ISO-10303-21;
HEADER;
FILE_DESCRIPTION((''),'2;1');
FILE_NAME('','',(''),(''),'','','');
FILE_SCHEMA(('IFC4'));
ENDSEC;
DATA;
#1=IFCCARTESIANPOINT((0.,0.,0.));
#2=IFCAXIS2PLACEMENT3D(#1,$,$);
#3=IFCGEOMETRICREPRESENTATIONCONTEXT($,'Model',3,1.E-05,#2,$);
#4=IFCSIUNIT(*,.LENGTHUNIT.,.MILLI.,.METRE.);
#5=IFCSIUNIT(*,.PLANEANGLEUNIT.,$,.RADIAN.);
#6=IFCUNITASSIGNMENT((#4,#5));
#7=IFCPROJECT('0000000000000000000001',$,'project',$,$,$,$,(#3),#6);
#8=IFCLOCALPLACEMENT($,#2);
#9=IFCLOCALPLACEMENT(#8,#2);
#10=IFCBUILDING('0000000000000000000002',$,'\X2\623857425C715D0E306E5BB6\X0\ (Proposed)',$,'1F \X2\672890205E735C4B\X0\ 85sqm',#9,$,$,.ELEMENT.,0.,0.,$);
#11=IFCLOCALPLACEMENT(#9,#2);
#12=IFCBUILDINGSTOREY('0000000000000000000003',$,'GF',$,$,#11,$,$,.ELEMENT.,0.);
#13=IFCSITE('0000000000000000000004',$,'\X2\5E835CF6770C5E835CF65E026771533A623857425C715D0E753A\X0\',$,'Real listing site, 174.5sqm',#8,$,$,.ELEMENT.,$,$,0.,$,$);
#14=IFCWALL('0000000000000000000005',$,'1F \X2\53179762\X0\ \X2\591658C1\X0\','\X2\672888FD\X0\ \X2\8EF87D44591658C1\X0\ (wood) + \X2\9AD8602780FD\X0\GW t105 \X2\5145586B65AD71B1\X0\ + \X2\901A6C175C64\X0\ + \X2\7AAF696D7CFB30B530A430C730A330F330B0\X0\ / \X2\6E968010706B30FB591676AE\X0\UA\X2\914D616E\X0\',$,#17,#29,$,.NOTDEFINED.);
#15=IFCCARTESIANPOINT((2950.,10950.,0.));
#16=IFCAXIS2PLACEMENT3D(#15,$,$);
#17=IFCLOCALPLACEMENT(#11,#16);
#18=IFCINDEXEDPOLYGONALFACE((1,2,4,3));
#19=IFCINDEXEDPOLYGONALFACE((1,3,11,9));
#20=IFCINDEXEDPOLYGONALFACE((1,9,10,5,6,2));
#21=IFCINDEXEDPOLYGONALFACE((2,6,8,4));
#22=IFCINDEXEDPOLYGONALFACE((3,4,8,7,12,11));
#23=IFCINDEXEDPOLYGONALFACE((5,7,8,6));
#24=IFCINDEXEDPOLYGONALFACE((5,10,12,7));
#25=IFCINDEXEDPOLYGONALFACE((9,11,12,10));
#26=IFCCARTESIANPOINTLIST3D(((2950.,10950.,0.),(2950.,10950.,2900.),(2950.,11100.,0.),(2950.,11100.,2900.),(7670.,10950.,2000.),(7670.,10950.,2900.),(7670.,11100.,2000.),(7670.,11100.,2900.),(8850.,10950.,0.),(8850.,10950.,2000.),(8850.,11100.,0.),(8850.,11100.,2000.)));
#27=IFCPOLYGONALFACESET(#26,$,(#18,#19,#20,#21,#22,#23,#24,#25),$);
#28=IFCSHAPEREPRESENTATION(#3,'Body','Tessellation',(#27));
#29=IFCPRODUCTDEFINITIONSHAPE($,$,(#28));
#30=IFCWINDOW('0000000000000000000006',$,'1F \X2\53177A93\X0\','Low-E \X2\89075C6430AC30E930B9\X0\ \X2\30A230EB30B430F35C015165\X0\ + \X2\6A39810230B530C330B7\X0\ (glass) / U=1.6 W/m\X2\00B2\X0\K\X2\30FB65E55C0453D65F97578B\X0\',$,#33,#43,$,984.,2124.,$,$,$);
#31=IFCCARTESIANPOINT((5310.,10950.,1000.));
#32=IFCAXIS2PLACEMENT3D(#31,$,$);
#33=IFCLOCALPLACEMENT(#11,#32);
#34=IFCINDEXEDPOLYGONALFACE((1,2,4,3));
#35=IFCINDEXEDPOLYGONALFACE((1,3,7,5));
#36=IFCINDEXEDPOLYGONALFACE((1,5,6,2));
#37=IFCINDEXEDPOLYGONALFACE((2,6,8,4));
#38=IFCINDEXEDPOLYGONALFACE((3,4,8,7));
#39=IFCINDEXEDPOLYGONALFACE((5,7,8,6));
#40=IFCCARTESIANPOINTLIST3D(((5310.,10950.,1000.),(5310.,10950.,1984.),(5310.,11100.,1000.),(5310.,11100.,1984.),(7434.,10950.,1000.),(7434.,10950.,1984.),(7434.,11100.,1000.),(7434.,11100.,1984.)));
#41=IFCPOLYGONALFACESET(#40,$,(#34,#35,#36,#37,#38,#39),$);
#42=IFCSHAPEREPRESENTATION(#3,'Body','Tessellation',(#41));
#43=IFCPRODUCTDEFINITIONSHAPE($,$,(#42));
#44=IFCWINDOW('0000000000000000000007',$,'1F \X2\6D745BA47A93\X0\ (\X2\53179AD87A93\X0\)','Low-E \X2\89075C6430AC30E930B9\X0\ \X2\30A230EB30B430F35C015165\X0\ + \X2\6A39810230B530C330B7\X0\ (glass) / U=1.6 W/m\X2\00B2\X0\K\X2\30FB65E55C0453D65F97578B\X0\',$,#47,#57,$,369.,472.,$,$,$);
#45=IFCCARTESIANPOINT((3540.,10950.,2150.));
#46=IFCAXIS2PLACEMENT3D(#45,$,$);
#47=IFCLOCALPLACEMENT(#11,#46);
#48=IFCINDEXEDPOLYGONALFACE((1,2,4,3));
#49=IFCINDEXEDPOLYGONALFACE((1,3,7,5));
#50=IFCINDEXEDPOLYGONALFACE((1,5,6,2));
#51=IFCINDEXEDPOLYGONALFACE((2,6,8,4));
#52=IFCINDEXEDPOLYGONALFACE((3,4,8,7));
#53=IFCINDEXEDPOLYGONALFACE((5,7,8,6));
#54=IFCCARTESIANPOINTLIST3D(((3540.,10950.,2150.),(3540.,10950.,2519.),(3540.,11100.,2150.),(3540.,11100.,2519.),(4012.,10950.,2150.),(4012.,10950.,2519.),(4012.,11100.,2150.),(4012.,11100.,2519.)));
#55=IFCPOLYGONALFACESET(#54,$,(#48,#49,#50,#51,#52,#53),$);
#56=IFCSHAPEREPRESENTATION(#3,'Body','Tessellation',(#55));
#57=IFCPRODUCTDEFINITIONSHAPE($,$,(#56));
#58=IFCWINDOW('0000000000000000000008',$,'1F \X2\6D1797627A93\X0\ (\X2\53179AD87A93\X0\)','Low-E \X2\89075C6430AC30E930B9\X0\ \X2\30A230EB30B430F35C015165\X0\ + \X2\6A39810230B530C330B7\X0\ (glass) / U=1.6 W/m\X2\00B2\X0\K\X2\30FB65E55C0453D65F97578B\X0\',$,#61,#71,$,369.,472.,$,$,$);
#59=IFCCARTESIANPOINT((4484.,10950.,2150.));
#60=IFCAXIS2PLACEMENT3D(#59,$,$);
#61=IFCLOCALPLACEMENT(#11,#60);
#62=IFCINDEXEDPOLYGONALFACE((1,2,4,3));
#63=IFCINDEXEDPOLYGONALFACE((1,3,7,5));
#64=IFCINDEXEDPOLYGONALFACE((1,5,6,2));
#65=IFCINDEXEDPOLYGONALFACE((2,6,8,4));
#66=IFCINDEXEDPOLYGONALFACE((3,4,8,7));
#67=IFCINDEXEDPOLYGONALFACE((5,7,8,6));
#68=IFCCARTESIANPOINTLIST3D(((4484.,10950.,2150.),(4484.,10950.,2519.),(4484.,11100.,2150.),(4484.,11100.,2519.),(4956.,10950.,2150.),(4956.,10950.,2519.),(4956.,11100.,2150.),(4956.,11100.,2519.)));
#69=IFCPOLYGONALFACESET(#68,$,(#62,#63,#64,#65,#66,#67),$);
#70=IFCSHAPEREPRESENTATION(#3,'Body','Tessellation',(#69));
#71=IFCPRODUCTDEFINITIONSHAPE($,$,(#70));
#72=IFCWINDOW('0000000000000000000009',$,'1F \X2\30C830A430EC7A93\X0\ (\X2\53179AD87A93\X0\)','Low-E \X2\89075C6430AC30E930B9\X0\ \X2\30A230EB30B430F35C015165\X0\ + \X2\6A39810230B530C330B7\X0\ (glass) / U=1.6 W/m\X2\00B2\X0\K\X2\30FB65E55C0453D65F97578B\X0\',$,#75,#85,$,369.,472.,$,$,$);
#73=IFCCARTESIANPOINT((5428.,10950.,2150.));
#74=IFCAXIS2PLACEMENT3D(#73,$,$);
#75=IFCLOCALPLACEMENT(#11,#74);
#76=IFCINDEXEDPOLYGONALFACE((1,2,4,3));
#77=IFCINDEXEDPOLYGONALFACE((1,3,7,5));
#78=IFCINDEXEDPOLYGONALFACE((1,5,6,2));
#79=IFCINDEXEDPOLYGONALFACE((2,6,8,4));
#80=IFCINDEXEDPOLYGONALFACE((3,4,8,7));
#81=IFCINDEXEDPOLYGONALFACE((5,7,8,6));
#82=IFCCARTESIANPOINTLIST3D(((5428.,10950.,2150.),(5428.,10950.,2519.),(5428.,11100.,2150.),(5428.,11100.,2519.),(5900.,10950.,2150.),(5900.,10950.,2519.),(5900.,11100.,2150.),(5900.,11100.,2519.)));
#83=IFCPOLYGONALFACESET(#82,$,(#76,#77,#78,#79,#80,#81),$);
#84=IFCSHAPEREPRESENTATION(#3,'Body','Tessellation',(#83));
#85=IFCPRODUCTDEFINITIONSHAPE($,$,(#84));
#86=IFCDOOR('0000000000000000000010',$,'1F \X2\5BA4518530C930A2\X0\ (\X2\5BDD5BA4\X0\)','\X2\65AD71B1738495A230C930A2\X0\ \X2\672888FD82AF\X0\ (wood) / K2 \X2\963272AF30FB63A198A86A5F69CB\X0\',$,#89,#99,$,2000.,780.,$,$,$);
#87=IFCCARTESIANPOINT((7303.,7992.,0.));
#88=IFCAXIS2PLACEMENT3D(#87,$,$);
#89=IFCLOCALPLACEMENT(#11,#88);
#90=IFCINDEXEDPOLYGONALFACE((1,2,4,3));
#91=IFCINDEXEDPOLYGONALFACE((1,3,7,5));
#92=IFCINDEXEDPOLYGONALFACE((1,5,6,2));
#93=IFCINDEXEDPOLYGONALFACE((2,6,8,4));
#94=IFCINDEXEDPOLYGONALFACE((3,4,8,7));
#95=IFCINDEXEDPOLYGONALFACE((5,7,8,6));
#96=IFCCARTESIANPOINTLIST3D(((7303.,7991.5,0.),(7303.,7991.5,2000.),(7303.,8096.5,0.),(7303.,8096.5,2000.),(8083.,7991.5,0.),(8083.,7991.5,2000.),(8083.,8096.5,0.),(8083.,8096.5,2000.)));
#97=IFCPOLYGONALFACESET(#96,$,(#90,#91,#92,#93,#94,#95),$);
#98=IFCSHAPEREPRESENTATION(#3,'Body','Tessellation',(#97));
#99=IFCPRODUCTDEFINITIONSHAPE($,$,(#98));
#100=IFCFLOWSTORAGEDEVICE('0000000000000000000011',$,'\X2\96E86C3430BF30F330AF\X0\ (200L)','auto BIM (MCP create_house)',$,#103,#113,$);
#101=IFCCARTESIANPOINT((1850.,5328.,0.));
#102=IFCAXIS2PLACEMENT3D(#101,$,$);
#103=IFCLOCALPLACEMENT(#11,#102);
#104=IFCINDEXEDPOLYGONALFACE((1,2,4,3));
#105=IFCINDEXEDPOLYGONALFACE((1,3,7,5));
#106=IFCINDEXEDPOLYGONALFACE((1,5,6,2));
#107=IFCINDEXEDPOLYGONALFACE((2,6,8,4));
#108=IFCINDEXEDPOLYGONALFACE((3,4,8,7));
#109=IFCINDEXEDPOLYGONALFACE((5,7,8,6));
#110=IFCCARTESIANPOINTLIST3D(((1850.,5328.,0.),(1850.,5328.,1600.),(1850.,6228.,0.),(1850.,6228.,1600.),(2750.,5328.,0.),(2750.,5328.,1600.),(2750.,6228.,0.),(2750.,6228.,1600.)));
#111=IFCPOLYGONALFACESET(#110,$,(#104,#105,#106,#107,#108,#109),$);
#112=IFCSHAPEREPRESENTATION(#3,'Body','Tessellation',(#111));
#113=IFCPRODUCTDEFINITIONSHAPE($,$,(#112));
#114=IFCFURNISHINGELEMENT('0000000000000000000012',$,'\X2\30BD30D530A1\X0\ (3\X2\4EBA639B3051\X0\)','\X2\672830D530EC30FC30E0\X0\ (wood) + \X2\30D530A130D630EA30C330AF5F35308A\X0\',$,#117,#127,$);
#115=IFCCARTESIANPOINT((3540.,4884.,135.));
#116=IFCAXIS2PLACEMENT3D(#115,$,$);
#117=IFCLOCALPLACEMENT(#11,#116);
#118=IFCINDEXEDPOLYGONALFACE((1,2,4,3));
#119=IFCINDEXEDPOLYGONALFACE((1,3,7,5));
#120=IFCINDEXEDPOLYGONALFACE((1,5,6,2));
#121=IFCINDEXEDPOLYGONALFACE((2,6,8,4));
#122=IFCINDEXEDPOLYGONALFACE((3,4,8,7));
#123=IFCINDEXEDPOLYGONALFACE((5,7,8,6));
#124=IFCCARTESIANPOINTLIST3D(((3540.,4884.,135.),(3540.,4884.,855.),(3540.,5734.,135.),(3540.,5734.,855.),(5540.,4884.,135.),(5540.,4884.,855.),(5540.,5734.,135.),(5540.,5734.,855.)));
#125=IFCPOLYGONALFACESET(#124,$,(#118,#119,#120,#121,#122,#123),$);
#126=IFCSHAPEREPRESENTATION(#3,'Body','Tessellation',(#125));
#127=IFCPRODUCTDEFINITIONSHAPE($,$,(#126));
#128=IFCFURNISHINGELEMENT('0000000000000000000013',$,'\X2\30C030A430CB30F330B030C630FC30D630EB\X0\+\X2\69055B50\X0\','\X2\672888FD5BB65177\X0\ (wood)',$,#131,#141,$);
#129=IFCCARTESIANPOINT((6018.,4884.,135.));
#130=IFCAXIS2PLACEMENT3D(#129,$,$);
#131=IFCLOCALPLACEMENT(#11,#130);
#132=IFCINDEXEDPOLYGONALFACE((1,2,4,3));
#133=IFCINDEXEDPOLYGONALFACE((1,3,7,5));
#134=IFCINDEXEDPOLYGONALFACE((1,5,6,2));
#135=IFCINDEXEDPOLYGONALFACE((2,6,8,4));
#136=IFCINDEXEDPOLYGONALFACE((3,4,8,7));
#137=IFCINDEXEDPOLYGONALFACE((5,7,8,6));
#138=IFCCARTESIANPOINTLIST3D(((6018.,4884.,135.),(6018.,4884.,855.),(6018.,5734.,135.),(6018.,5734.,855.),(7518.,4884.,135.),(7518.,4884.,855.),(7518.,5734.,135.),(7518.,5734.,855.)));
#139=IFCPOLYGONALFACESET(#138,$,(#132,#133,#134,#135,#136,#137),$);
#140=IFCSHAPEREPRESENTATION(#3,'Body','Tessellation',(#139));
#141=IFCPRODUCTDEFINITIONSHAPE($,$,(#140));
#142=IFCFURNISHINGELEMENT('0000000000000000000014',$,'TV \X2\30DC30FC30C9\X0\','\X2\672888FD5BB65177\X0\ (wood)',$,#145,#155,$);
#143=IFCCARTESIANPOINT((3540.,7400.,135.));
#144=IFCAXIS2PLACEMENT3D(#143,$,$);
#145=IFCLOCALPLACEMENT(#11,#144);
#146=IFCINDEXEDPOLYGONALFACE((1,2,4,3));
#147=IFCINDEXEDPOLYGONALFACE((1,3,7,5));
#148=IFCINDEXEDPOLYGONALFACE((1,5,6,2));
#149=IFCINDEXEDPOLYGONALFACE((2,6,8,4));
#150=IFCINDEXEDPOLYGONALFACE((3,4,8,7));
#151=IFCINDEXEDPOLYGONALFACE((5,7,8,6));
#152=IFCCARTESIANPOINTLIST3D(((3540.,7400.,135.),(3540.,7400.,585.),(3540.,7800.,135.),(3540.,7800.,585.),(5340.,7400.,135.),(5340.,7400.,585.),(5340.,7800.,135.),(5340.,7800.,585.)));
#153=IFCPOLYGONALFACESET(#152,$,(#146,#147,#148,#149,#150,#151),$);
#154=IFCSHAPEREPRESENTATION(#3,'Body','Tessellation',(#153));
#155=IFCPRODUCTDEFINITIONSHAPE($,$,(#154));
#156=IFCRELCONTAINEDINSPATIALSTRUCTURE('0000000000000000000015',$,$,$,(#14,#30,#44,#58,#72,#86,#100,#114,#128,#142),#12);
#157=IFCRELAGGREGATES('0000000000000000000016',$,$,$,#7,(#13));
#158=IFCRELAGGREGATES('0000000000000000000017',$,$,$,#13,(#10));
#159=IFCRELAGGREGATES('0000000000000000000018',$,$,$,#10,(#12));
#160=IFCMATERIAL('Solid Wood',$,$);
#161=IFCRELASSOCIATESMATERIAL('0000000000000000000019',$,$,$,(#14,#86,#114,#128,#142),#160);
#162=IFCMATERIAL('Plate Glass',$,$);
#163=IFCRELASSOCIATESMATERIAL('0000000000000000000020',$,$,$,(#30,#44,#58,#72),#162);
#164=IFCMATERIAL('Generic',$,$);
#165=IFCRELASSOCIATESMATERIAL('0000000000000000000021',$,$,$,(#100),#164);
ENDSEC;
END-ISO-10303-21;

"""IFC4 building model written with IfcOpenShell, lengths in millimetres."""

from ifc_helpers import new_model, si_unit, frame, frame_2d, origin, place, context, project, spatial, rectangle, extrude, material, element, fill, save


model = new_model("IFC4")

# Units and contexts
model_context = context("Model", 3, precision=1e-05, world=origin())
ifc_project = project(units=[si_unit("LENGTHUNIT", "METRE", prefix="MILLI"), si_unit("PLANEANGLEUNIT", "RADIAN")], contexts=[model_context])

# Site, building, storey
site_placement = place(None, origin())
site = spatial("IfcSite", under=ifc_project, at=site_placement, Name="広島県広島市東区戸坂山崎町", ObjectType="Real listing site, 174.5sqm", CompositionType="ELEMENT", RefElevation=0.0)
building_placement = place(site_placement, origin())
building = spatial("IfcBuilding", under=site, at=building_placement, Name="戸坂山崎の家 (Proposed)", ObjectType="1F 木造平屋 85sqm", CompositionType="ELEMENT", ElevationOfRefHeight=0.0, ElevationOfTerrain=0.0)
storey_placement = place(building_placement, origin())
storey = spatial("IfcBuildingStorey", under=building, at=storey_placement, Name="GF", CompositionType="ELEMENT", Elevation=0.0)

# Wall, openings, windows
ifc_material_1 = material(Name="Solid Wood")
wall_1_placement = place(storey_placement, frame((2950.0, 10950.0, 0.0)))
wall_1 = element("IfcWall", 1, at=wall_1_placement, inside=storey, material=ifc_material_1, Name="1F 北面 外壁", Description="木製 軸組外壁 (wood) + 高性能GW t105 充填断熱 + 通気層 + 窯業系サイディング / 準耐火・外皮UA配慮", PredefinedType="NOTDEFINED", context=model_context, shape_type="SweptSolid", body=[
    extrude(rectangle(XDim=5900.0, YDim=150.0, at=frame_2d((2950.0, 75.0))), frame((2950.0, 10950.0, 0.0)), (0.0, 0.0, 1.0), 2900.0),
])
opening_1_placement = place(storey_placement, frame((5310.0, 10950.0, 1000.0)))
opening_1 = element("IfcOpeningElement", 2, at=opening_1_placement, cuts=wall_1, PredefinedType="NOTDEFINED", context=model_context, shape_type="SweptSolid", body=[
    extrude(rectangle(XDim=2124.0, YDim=150.0, at=frame_2d((1062.0, 75.0))), frame((5310.0, 10950.0, 1000.0)), (0.0, 0.0, 1.0), 984.0),
])
opening_2_placement = place(storey_placement, frame((3540.0, 10950.0, 2150.0)))
opening_2 = element("IfcOpeningElement", 3, at=opening_2_placement, cuts=wall_1, PredefinedType="NOTDEFINED", context=model_context, shape_type="SweptSolid", body=[
    extrude(rectangle(XDim=472.0, YDim=150.0, at=frame_2d((236.0, 75.0))), frame((3540.0, 10950.0, 2150.0)), (0.0, 0.0, 1.0), 369.0),
])
opening_3_placement = place(storey_placement, frame((4484.0, 10950.0, 2150.0)))
opening_3 = element("IfcOpeningElement", 4, at=opening_3_placement, cuts=wall_1, PredefinedType="NOTDEFINED", context=model_context, shape_type="SweptSolid", body=[
    extrude(rectangle(XDim=472.0, YDim=150.0, at=frame_2d((236.0, 75.0))), frame((4484.0, 10950.0, 2150.0)), (0.0, 0.0, 1.0), 369.0),
])
opening_4_placement = place(storey_placement, frame((5428.0, 10950.0, 2150.0)))
opening_4 = element("IfcOpeningElement", 5, at=opening_4_placement, cuts=wall_1, PredefinedType="NOTDEFINED", context=model_context, shape_type="SweptSolid", body=[
    extrude(rectangle(XDim=472.0, YDim=150.0, at=frame_2d((236.0, 75.0))), frame((5428.0, 10950.0, 2150.0)), (0.0, 0.0, 1.0), 369.0),
])
ifc_material_2 = material(Name="Plate Glass")
window_1_placement = place(storey_placement, frame((5310.0, 10950.0, 1000.0)))
window_1 = element("IfcWindow", 6, at=window_1_placement, inside=storey, material=ifc_material_2, Name="1F 北窓", Description="Low-E 複層ガラス アルゴン封入 + 樹脂サッシ (glass) / U=1.6 W/m²K・日射取得型", OverallHeight=984.0, OverallWidth=2124.0, context=model_context, shape_type="SweptSolid", body=[
    extrude(rectangle(XDim=2124.0, YDim=150.0, at=frame_2d((1062.0, 75.0))), frame((5310.0, 10950.0, 1000.0)), (0.0, 0.0, 1.0), 984.0),
])
fill(opening_1, window_1)
window_2_placement = place(storey_placement, frame((3540.0, 10950.0, 2150.0)))
window_2 = element("IfcWindow", 7, at=window_2_placement, inside=storey, material=ifc_material_2, Name="1F 浴室窓 (北高窓)", Description="Low-E 複層ガラス アルゴン封入 + 樹脂サッシ (glass) / U=1.6 W/m²K・日射取得型", OverallHeight=369.0, OverallWidth=472.0, context=model_context, shape_type="SweptSolid", body=[
    extrude(rectangle(XDim=472.0, YDim=150.0, at=frame_2d((236.0, 75.0))), frame((3540.0, 10950.0, 2150.0)), (0.0, 0.0, 1.0), 369.0),
])
fill(opening_2, window_2)
window_3_placement = place(storey_placement, frame((4484.0, 10950.0, 2150.0)))
window_3 = element("IfcWindow", 8, at=window_3_placement, inside=storey, material=ifc_material_2, Name="1F 洗面窓 (北高窓)", Description="Low-E 複層ガラス アルゴン封入 + 樹脂サッシ (glass) / U=1.6 W/m²K・日射取得型", OverallHeight=369.0, OverallWidth=472.0, context=model_context, shape_type="SweptSolid", body=[
    extrude(rectangle(XDim=472.0, YDim=150.0, at=frame_2d((236.0, 75.0))), frame((4484.0, 10950.0, 2150.0)), (0.0, 0.0, 1.0), 369.0),
])
fill(opening_3, window_3)
window_4_placement = place(storey_placement, frame((5428.0, 10950.0, 2150.0)))
window_4 = element("IfcWindow", 9, at=window_4_placement, inside=storey, material=ifc_material_2, Name="1F トイレ窓 (北高窓)", Description="Low-E 複層ガラス アルゴン封入 + 樹脂サッシ (glass) / U=1.6 W/m²K・日射取得型", OverallHeight=369.0, OverallWidth=472.0, context=model_context, shape_type="SweptSolid", body=[
    extrude(rectangle(XDim=472.0, YDim=150.0, at=frame_2d((236.0, 75.0))), frame((5428.0, 10950.0, 2150.0)), (0.0, 0.0, 1.0), 369.0),
])
fill(opening_4, window_4)

# Door
door_1_placement = place(storey_placement, frame((7303.0, 7992.0, 0.0)))
element("IfcDoor", 10, at=door_1_placement, inside=storey, material=ifc_material_1, Name="1F 室内ドア (寝室)", Description="断熱玄関ドア 木製芯 (wood) / K2 防犯・採風機構", OverallHeight=2000.0, OverallWidth=780.0, context=model_context, shape_type="SweptSolid", body=[
    extrude(rectangle(XDim=780.0, YDim=105.0, at=frame_2d((390.0, 52.0))), frame((7303.0, 7992.0, 0.0)), (0.0, 0.0, 1.0), 2000.0),
])

# Flow storage device
ifc_material_3 = material(Name="Generic")
flow_storage_device_placement = place(storey_placement, frame((1850.0, 5328.0, 0.0)))
element("IfcFlowStorageDevice", 11, at=flow_storage_device_placement, inside=storey, material=ifc_material_3, Name="雨水タンク (200L)", Description="auto BIM (MCP create_house)", context=model_context, shape_type="SweptSolid", body=[
    extrude(rectangle(XDim=900.0, YDim=900.0, at=frame_2d((450.0, 450.0))), frame((1850.0, 5328.0, 0.0)), (0.0, 0.0, 1.0), 1600.0),
])

# Furnishing elements
furnishing_1_placement = place(storey_placement, frame((3540.0, 4884.0, 135.0)))
element("IfcFurnishingElement", 12, at=furnishing_1_placement, inside=storey, material=ifc_material_1, Name="ソファ (3人掛け)", Description="木フレーム (wood) + ファブリック張り", context=model_context, shape_type="SweptSolid", body=[
    extrude(rectangle(XDim=2000.0, YDim=850.0, at=frame_2d((1000.0, 425.0))), frame((3540.0, 4884.0, 135.0)), (0.0, 0.0, 1.0), 720.0),
])
furnishing_2_placement = place(storey_placement, frame((6018.0, 4884.0, 135.0)))
element("IfcFurnishingElement", 13, at=furnishing_2_placement, inside=storey, material=ifc_material_1, Name="ダイニングテーブル+椅子", Description="木製家具 (wood)", context=model_context, shape_type="SweptSolid", body=[
    extrude(rectangle(XDim=1500.0, YDim=850.0, at=frame_2d((750.0, 425.0))), frame((6018.0, 4884.0, 135.0)), (0.0, 0.0, 1.0), 720.0),
])
furnishing_3_placement = place(storey_placement, frame((3540.0, 7400.0, 135.0)))
element("IfcFurnishingElement", 14, at=furnishing_3_placement, inside=storey, material=ifc_material_1, Name="TV ボード", Description="木製家具 (wood)", context=model_context, shape_type="SweptSolid", body=[
    extrude(rectangle(XDim=1800.0, YDim=400.0, at=frame_2d((900.0, 200.0))), frame((3540.0, 7400.0, 135.0)), (0.0, 0.0, 1.0), 450.0),
])

save(model, "model.ifc")
